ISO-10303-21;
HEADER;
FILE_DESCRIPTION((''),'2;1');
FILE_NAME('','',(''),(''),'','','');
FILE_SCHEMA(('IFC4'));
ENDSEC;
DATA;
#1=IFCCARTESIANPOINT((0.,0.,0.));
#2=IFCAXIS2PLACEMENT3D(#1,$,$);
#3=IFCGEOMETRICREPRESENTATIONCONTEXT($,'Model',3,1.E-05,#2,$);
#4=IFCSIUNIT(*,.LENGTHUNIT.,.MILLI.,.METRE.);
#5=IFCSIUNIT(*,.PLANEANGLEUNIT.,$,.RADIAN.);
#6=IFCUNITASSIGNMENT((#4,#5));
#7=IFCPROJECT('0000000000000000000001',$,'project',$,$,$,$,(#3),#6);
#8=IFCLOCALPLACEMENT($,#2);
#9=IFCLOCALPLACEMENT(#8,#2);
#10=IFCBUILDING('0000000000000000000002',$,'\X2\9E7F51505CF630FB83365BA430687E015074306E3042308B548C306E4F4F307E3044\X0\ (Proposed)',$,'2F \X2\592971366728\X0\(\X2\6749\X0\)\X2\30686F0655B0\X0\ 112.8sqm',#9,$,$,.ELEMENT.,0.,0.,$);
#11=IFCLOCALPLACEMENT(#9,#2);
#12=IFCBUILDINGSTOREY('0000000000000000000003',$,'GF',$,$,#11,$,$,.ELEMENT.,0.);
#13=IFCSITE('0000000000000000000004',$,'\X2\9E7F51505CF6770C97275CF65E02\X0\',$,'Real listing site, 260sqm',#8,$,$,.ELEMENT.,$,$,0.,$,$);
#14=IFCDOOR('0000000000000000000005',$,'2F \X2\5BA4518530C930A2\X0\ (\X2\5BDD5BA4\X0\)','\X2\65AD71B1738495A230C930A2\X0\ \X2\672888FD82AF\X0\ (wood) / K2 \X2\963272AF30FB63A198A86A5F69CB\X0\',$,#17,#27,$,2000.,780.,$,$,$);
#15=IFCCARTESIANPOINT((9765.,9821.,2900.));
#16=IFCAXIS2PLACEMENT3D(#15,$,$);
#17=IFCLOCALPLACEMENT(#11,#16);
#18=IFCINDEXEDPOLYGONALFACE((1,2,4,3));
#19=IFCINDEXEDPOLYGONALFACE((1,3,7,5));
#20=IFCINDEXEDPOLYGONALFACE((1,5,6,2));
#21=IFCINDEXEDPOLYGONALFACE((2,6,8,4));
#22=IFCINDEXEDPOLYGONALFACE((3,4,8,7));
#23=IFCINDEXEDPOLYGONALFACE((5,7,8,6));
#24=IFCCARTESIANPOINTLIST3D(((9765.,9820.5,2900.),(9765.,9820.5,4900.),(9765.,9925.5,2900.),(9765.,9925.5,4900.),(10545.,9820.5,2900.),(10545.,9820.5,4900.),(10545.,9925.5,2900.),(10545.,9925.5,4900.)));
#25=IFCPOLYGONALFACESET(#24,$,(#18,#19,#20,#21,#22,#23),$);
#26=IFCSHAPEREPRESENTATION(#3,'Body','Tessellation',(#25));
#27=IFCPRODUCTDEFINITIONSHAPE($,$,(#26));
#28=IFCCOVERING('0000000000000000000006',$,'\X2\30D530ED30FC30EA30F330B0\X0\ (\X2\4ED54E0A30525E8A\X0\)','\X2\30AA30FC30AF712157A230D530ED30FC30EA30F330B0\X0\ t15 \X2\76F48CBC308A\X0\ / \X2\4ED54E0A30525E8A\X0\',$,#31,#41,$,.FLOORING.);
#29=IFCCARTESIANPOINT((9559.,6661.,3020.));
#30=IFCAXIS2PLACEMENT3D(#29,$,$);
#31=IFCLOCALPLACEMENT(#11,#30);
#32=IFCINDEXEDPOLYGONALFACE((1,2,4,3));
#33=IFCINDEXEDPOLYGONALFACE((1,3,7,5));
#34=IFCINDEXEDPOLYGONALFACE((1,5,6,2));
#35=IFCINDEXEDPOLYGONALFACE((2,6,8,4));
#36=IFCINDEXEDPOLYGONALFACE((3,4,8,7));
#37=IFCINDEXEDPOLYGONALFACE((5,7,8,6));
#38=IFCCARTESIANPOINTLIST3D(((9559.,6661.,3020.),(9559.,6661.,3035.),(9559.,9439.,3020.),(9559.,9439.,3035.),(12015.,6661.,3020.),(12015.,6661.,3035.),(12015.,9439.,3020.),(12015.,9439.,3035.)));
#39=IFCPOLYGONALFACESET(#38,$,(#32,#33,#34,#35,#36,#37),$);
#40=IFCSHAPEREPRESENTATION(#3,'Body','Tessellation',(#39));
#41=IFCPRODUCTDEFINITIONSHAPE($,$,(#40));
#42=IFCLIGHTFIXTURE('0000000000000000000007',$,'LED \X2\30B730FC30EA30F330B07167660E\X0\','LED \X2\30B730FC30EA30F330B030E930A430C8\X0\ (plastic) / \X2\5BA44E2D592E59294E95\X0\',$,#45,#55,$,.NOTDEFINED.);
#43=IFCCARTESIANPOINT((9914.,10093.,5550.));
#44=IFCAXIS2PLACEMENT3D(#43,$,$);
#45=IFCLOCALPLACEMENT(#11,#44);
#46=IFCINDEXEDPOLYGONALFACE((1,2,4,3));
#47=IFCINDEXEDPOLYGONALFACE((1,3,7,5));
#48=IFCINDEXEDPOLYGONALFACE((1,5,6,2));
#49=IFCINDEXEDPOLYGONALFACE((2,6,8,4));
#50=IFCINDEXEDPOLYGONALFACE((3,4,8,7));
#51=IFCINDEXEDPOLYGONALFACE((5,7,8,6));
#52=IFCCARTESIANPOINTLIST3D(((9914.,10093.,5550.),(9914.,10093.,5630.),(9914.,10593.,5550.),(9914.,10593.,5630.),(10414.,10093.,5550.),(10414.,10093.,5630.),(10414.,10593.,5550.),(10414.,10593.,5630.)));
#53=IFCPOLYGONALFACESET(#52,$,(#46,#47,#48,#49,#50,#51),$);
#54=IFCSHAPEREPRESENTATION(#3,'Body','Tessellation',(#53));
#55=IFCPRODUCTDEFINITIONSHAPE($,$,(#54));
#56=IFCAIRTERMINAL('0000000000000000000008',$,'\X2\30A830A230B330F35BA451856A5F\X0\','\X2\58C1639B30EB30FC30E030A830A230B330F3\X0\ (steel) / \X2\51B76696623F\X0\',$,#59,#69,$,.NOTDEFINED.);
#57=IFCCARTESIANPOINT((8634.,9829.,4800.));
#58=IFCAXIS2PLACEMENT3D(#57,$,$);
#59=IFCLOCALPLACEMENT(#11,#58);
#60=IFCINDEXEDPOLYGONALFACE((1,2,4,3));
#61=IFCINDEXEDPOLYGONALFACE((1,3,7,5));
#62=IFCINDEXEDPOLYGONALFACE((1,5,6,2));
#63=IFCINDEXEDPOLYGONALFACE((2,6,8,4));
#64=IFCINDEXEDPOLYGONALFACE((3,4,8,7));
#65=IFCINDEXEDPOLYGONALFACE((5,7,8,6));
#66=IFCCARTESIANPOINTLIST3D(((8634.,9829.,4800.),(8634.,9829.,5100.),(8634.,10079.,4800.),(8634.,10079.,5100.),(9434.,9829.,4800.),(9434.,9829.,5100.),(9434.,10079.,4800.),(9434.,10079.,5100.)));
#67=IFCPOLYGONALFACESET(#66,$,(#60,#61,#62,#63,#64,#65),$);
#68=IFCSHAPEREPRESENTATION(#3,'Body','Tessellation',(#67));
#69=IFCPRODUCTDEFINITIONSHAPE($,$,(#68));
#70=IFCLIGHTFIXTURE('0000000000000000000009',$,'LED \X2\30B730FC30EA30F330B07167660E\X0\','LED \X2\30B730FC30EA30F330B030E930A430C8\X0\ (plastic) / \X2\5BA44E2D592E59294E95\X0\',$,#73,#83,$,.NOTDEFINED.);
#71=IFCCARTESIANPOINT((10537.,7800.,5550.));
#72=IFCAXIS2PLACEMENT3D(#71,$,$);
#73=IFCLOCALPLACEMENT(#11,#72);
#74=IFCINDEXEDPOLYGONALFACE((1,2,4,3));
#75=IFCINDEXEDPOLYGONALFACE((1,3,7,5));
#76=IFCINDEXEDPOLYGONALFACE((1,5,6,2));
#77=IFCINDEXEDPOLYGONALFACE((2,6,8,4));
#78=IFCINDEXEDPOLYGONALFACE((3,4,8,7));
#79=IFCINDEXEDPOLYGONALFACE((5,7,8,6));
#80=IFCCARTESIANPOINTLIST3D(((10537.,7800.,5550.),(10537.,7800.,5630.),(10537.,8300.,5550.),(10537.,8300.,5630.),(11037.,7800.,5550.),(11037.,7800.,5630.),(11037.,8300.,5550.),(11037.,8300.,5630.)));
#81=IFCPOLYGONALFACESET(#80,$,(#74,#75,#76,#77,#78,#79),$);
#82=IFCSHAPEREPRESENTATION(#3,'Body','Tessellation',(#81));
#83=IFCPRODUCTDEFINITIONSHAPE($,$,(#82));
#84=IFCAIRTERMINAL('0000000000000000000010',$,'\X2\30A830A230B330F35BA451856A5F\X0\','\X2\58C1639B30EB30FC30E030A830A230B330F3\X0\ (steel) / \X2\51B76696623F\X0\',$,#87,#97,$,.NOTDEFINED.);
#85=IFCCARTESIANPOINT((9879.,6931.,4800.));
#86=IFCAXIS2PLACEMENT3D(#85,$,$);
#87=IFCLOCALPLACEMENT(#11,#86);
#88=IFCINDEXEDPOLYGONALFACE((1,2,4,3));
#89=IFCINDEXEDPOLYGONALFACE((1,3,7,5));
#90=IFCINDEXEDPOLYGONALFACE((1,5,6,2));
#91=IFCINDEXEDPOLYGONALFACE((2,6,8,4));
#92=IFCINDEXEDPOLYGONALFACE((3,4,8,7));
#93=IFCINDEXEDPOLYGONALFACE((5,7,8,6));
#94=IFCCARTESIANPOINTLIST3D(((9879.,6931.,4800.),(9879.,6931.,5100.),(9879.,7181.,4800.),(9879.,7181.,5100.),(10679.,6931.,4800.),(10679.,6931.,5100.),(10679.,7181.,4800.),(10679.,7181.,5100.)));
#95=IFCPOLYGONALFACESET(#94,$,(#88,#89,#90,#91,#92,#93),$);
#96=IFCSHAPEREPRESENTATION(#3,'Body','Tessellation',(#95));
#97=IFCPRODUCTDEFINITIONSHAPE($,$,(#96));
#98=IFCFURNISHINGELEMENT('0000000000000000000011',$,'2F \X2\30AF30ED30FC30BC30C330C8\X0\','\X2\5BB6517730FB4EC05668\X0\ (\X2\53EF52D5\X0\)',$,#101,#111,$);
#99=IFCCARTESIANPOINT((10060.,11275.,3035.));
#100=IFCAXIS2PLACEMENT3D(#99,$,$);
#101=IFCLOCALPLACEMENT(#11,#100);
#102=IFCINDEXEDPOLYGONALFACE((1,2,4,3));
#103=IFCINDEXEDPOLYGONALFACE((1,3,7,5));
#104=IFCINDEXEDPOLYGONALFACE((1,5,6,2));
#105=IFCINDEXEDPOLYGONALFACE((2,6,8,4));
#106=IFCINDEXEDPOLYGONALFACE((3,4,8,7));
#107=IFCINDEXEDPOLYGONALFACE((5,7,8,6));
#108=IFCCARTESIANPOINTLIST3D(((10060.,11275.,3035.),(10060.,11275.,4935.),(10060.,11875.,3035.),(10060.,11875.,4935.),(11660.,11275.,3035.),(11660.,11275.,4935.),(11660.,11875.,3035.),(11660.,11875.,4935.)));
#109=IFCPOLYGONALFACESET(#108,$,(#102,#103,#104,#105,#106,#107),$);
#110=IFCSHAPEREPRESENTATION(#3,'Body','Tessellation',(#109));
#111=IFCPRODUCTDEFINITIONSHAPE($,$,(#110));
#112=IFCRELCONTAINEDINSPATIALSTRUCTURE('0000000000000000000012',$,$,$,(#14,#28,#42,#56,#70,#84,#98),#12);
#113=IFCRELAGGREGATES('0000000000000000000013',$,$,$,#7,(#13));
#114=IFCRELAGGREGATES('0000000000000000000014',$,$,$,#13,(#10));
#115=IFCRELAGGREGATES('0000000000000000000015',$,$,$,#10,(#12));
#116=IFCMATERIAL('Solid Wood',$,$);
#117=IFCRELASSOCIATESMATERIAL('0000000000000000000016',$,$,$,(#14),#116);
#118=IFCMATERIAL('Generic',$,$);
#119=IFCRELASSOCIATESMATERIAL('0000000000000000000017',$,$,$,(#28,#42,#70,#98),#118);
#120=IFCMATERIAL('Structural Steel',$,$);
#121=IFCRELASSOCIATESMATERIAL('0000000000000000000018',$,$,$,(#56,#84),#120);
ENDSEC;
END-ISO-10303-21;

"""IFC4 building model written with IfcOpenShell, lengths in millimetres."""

from ifc_helpers import new_model, si_unit, frame, frame_2d, origin, place, context, project, spatial, rectangle, extrude, material, element, save


model = new_model("IFC4")

# Units and contexts
model_context = context("Model", 3, precision=1e-05, world=origin())
ifc_project = project(units=[si_unit("LENGTHUNIT", "METRE", prefix="MILLI"), si_unit("PLANEANGLEUNIT", "RADIAN")], contexts=[model_context])

# Site, building, storey
site_placement = place(None, origin())
site = spatial("IfcSite", under=ifc_project, at=site_placement, Name="鹿児島県霧島市", ObjectType="Real listing site, 260sqm", CompositionType="ELEMENT", RefElevation=0.0)
building_placement = place(site_placement, origin())
building = spatial("IfcBuilding", under=site, at=building_placement, Name="鹿児島・茶室と縁側のある和の住まい (Proposed)", ObjectType="2F 天然木(杉)と漆喰 112.8sqm", CompositionType="ELEMENT", ElevationOfRefHeight=0.0, ElevationOfTerrain=0.0)
storey_placement = place(building_placement, origin())
storey = spatial("IfcBuildingStorey", under=building, at=storey_placement, Name="GF", CompositionType="ELEMENT", Elevation=0.0)

# Shared definitions
ifc_material_1 = material(Name="Solid Wood")

# Door
door_placement = place(storey_placement, frame((9765.0, 9821.0, 2900.0)))
element("IfcDoor", 1, at=door_placement, inside=storey, material=ifc_material_1, Name="2F 室内ドア (寝室)", Description="断熱玄関ドア 木製芯 (wood) / K2 防犯・採風機構", OverallHeight=2000.0, OverallWidth=780.0, context=model_context, shape_type="SweptSolid", body=[
    extrude(rectangle(XDim=780.0, YDim=105.0, at=frame_2d((390.0, 52.0))), frame((9765.0, 9821.0, 2900.0)), (0.0, 0.0, 1.0), 2000.0),
])

# Covering
ifc_material_2 = material(Name="Generic")
covering_placement = place(storey_placement, frame((9559.0, 6661.0, 3020.0)))
element("IfcCovering", 2, at=covering_placement, inside=storey, material=ifc_material_2, Name="フローリング (仕上げ床)", Description="オーク無垢フローリング t15 直貼り / 仕上げ床", PredefinedType="FLOORING", context=model_context, shape_type="SweptSolid", body=[
    extrude(rectangle(XDim=2456.0, YDim=2778.0, at=frame_2d((1228.0, 1389.0))), frame((9559.0, 6661.0, 3020.0)), (0.0, 0.0, 1.0), 15.0),
])

# Light fixture
light_fixture_1_placement = place(storey_placement, frame((9914.0, 10093.0, 5550.0)))
element("IfcLightFixture", 3, at=light_fixture_1_placement, inside=storey, material=ifc_material_2, Name="LED シーリング照明", Description="LED シーリングライト (plastic) / 室中央天井", PredefinedType="NOTDEFINED", context=model_context, shape_type="SweptSolid", body=[
    extrude(rectangle(XDim=500.0, YDim=500.0, at=frame_2d((250.0, 250.0))), frame((9914.0, 10093.0, 5550.0)), (0.0, 0.0, 1.0), 80.0),
])

# Air terminal
ifc_material_3 = material(Name="Structural Steel")
air_terminal_1_placement = place(storey_placement, frame((8634.0, 9829.0, 4800.0)))
element("IfcAirTerminal", 4, at=air_terminal_1_placement, inside=storey, material=ifc_material_3, Name="エアコン室内機", Description="壁掛ルームエアコン (steel) / 冷暖房", PredefinedType="NOTDEFINED", context=model_context, shape_type="SweptSolid", body=[
    extrude(rectangle(XDim=800.0, YDim=250.0, at=frame_2d((400.0, 125.0))), frame((8634.0, 9829.0, 4800.0)), (0.0, 0.0, 1.0), 300.0),
])

# Light fixture
light_fixture_2_placement = place(storey_placement, frame((10537.0, 7800.0, 5550.0)))
element("IfcLightFixture", 5, at=light_fixture_2_placement, inside=storey, material=ifc_material_2, Name="LED シーリング照明", Description="LED シーリングライト (plastic) / 室中央天井", PredefinedType="NOTDEFINED", context=model_context, shape_type="SweptSolid", body=[
    extrude(rectangle(XDim=500.0, YDim=500.0, at=frame_2d((250.0, 250.0))), frame((10537.0, 7800.0, 5550.0)), (0.0, 0.0, 1.0), 80.0),
])

# Air terminal
air_terminal_2_placement = place(storey_placement, frame((9879.0, 6931.0, 4800.0)))
element("IfcAirTerminal", 6, at=air_terminal_2_placement, inside=storey, material=ifc_material_3, Name="エアコン室内機", Description="壁掛ルームエアコン (steel) / 冷暖房", PredefinedType="NOTDEFINED", context=model_context, shape_type="SweptSolid", body=[
    extrude(rectangle(XDim=800.0, YDim=250.0, at=frame_2d((400.0, 125.0))), frame((9879.0, 6931.0, 4800.0)), (0.0, 0.0, 1.0), 300.0),
])

# Furnishing element
furnishing_placement = place(storey_placement, frame((10060.0, 11275.0, 3035.0)))
element("IfcFurnishingElement", 7, at=furnishing_placement, inside=storey, material=ifc_material_2, Name="2F クローゼット", Description="家具・什器 (可動)", context=model_context, shape_type="SweptSolid", body=[
    extrude(rectangle(XDim=1600.0, YDim=600.0, at=frame_2d((800.0, 300.0))), frame((10060.0, 11275.0, 3035.0)), (0.0, 0.0, 1.0), 1900.0),
])

save(model, "model.ifc")
